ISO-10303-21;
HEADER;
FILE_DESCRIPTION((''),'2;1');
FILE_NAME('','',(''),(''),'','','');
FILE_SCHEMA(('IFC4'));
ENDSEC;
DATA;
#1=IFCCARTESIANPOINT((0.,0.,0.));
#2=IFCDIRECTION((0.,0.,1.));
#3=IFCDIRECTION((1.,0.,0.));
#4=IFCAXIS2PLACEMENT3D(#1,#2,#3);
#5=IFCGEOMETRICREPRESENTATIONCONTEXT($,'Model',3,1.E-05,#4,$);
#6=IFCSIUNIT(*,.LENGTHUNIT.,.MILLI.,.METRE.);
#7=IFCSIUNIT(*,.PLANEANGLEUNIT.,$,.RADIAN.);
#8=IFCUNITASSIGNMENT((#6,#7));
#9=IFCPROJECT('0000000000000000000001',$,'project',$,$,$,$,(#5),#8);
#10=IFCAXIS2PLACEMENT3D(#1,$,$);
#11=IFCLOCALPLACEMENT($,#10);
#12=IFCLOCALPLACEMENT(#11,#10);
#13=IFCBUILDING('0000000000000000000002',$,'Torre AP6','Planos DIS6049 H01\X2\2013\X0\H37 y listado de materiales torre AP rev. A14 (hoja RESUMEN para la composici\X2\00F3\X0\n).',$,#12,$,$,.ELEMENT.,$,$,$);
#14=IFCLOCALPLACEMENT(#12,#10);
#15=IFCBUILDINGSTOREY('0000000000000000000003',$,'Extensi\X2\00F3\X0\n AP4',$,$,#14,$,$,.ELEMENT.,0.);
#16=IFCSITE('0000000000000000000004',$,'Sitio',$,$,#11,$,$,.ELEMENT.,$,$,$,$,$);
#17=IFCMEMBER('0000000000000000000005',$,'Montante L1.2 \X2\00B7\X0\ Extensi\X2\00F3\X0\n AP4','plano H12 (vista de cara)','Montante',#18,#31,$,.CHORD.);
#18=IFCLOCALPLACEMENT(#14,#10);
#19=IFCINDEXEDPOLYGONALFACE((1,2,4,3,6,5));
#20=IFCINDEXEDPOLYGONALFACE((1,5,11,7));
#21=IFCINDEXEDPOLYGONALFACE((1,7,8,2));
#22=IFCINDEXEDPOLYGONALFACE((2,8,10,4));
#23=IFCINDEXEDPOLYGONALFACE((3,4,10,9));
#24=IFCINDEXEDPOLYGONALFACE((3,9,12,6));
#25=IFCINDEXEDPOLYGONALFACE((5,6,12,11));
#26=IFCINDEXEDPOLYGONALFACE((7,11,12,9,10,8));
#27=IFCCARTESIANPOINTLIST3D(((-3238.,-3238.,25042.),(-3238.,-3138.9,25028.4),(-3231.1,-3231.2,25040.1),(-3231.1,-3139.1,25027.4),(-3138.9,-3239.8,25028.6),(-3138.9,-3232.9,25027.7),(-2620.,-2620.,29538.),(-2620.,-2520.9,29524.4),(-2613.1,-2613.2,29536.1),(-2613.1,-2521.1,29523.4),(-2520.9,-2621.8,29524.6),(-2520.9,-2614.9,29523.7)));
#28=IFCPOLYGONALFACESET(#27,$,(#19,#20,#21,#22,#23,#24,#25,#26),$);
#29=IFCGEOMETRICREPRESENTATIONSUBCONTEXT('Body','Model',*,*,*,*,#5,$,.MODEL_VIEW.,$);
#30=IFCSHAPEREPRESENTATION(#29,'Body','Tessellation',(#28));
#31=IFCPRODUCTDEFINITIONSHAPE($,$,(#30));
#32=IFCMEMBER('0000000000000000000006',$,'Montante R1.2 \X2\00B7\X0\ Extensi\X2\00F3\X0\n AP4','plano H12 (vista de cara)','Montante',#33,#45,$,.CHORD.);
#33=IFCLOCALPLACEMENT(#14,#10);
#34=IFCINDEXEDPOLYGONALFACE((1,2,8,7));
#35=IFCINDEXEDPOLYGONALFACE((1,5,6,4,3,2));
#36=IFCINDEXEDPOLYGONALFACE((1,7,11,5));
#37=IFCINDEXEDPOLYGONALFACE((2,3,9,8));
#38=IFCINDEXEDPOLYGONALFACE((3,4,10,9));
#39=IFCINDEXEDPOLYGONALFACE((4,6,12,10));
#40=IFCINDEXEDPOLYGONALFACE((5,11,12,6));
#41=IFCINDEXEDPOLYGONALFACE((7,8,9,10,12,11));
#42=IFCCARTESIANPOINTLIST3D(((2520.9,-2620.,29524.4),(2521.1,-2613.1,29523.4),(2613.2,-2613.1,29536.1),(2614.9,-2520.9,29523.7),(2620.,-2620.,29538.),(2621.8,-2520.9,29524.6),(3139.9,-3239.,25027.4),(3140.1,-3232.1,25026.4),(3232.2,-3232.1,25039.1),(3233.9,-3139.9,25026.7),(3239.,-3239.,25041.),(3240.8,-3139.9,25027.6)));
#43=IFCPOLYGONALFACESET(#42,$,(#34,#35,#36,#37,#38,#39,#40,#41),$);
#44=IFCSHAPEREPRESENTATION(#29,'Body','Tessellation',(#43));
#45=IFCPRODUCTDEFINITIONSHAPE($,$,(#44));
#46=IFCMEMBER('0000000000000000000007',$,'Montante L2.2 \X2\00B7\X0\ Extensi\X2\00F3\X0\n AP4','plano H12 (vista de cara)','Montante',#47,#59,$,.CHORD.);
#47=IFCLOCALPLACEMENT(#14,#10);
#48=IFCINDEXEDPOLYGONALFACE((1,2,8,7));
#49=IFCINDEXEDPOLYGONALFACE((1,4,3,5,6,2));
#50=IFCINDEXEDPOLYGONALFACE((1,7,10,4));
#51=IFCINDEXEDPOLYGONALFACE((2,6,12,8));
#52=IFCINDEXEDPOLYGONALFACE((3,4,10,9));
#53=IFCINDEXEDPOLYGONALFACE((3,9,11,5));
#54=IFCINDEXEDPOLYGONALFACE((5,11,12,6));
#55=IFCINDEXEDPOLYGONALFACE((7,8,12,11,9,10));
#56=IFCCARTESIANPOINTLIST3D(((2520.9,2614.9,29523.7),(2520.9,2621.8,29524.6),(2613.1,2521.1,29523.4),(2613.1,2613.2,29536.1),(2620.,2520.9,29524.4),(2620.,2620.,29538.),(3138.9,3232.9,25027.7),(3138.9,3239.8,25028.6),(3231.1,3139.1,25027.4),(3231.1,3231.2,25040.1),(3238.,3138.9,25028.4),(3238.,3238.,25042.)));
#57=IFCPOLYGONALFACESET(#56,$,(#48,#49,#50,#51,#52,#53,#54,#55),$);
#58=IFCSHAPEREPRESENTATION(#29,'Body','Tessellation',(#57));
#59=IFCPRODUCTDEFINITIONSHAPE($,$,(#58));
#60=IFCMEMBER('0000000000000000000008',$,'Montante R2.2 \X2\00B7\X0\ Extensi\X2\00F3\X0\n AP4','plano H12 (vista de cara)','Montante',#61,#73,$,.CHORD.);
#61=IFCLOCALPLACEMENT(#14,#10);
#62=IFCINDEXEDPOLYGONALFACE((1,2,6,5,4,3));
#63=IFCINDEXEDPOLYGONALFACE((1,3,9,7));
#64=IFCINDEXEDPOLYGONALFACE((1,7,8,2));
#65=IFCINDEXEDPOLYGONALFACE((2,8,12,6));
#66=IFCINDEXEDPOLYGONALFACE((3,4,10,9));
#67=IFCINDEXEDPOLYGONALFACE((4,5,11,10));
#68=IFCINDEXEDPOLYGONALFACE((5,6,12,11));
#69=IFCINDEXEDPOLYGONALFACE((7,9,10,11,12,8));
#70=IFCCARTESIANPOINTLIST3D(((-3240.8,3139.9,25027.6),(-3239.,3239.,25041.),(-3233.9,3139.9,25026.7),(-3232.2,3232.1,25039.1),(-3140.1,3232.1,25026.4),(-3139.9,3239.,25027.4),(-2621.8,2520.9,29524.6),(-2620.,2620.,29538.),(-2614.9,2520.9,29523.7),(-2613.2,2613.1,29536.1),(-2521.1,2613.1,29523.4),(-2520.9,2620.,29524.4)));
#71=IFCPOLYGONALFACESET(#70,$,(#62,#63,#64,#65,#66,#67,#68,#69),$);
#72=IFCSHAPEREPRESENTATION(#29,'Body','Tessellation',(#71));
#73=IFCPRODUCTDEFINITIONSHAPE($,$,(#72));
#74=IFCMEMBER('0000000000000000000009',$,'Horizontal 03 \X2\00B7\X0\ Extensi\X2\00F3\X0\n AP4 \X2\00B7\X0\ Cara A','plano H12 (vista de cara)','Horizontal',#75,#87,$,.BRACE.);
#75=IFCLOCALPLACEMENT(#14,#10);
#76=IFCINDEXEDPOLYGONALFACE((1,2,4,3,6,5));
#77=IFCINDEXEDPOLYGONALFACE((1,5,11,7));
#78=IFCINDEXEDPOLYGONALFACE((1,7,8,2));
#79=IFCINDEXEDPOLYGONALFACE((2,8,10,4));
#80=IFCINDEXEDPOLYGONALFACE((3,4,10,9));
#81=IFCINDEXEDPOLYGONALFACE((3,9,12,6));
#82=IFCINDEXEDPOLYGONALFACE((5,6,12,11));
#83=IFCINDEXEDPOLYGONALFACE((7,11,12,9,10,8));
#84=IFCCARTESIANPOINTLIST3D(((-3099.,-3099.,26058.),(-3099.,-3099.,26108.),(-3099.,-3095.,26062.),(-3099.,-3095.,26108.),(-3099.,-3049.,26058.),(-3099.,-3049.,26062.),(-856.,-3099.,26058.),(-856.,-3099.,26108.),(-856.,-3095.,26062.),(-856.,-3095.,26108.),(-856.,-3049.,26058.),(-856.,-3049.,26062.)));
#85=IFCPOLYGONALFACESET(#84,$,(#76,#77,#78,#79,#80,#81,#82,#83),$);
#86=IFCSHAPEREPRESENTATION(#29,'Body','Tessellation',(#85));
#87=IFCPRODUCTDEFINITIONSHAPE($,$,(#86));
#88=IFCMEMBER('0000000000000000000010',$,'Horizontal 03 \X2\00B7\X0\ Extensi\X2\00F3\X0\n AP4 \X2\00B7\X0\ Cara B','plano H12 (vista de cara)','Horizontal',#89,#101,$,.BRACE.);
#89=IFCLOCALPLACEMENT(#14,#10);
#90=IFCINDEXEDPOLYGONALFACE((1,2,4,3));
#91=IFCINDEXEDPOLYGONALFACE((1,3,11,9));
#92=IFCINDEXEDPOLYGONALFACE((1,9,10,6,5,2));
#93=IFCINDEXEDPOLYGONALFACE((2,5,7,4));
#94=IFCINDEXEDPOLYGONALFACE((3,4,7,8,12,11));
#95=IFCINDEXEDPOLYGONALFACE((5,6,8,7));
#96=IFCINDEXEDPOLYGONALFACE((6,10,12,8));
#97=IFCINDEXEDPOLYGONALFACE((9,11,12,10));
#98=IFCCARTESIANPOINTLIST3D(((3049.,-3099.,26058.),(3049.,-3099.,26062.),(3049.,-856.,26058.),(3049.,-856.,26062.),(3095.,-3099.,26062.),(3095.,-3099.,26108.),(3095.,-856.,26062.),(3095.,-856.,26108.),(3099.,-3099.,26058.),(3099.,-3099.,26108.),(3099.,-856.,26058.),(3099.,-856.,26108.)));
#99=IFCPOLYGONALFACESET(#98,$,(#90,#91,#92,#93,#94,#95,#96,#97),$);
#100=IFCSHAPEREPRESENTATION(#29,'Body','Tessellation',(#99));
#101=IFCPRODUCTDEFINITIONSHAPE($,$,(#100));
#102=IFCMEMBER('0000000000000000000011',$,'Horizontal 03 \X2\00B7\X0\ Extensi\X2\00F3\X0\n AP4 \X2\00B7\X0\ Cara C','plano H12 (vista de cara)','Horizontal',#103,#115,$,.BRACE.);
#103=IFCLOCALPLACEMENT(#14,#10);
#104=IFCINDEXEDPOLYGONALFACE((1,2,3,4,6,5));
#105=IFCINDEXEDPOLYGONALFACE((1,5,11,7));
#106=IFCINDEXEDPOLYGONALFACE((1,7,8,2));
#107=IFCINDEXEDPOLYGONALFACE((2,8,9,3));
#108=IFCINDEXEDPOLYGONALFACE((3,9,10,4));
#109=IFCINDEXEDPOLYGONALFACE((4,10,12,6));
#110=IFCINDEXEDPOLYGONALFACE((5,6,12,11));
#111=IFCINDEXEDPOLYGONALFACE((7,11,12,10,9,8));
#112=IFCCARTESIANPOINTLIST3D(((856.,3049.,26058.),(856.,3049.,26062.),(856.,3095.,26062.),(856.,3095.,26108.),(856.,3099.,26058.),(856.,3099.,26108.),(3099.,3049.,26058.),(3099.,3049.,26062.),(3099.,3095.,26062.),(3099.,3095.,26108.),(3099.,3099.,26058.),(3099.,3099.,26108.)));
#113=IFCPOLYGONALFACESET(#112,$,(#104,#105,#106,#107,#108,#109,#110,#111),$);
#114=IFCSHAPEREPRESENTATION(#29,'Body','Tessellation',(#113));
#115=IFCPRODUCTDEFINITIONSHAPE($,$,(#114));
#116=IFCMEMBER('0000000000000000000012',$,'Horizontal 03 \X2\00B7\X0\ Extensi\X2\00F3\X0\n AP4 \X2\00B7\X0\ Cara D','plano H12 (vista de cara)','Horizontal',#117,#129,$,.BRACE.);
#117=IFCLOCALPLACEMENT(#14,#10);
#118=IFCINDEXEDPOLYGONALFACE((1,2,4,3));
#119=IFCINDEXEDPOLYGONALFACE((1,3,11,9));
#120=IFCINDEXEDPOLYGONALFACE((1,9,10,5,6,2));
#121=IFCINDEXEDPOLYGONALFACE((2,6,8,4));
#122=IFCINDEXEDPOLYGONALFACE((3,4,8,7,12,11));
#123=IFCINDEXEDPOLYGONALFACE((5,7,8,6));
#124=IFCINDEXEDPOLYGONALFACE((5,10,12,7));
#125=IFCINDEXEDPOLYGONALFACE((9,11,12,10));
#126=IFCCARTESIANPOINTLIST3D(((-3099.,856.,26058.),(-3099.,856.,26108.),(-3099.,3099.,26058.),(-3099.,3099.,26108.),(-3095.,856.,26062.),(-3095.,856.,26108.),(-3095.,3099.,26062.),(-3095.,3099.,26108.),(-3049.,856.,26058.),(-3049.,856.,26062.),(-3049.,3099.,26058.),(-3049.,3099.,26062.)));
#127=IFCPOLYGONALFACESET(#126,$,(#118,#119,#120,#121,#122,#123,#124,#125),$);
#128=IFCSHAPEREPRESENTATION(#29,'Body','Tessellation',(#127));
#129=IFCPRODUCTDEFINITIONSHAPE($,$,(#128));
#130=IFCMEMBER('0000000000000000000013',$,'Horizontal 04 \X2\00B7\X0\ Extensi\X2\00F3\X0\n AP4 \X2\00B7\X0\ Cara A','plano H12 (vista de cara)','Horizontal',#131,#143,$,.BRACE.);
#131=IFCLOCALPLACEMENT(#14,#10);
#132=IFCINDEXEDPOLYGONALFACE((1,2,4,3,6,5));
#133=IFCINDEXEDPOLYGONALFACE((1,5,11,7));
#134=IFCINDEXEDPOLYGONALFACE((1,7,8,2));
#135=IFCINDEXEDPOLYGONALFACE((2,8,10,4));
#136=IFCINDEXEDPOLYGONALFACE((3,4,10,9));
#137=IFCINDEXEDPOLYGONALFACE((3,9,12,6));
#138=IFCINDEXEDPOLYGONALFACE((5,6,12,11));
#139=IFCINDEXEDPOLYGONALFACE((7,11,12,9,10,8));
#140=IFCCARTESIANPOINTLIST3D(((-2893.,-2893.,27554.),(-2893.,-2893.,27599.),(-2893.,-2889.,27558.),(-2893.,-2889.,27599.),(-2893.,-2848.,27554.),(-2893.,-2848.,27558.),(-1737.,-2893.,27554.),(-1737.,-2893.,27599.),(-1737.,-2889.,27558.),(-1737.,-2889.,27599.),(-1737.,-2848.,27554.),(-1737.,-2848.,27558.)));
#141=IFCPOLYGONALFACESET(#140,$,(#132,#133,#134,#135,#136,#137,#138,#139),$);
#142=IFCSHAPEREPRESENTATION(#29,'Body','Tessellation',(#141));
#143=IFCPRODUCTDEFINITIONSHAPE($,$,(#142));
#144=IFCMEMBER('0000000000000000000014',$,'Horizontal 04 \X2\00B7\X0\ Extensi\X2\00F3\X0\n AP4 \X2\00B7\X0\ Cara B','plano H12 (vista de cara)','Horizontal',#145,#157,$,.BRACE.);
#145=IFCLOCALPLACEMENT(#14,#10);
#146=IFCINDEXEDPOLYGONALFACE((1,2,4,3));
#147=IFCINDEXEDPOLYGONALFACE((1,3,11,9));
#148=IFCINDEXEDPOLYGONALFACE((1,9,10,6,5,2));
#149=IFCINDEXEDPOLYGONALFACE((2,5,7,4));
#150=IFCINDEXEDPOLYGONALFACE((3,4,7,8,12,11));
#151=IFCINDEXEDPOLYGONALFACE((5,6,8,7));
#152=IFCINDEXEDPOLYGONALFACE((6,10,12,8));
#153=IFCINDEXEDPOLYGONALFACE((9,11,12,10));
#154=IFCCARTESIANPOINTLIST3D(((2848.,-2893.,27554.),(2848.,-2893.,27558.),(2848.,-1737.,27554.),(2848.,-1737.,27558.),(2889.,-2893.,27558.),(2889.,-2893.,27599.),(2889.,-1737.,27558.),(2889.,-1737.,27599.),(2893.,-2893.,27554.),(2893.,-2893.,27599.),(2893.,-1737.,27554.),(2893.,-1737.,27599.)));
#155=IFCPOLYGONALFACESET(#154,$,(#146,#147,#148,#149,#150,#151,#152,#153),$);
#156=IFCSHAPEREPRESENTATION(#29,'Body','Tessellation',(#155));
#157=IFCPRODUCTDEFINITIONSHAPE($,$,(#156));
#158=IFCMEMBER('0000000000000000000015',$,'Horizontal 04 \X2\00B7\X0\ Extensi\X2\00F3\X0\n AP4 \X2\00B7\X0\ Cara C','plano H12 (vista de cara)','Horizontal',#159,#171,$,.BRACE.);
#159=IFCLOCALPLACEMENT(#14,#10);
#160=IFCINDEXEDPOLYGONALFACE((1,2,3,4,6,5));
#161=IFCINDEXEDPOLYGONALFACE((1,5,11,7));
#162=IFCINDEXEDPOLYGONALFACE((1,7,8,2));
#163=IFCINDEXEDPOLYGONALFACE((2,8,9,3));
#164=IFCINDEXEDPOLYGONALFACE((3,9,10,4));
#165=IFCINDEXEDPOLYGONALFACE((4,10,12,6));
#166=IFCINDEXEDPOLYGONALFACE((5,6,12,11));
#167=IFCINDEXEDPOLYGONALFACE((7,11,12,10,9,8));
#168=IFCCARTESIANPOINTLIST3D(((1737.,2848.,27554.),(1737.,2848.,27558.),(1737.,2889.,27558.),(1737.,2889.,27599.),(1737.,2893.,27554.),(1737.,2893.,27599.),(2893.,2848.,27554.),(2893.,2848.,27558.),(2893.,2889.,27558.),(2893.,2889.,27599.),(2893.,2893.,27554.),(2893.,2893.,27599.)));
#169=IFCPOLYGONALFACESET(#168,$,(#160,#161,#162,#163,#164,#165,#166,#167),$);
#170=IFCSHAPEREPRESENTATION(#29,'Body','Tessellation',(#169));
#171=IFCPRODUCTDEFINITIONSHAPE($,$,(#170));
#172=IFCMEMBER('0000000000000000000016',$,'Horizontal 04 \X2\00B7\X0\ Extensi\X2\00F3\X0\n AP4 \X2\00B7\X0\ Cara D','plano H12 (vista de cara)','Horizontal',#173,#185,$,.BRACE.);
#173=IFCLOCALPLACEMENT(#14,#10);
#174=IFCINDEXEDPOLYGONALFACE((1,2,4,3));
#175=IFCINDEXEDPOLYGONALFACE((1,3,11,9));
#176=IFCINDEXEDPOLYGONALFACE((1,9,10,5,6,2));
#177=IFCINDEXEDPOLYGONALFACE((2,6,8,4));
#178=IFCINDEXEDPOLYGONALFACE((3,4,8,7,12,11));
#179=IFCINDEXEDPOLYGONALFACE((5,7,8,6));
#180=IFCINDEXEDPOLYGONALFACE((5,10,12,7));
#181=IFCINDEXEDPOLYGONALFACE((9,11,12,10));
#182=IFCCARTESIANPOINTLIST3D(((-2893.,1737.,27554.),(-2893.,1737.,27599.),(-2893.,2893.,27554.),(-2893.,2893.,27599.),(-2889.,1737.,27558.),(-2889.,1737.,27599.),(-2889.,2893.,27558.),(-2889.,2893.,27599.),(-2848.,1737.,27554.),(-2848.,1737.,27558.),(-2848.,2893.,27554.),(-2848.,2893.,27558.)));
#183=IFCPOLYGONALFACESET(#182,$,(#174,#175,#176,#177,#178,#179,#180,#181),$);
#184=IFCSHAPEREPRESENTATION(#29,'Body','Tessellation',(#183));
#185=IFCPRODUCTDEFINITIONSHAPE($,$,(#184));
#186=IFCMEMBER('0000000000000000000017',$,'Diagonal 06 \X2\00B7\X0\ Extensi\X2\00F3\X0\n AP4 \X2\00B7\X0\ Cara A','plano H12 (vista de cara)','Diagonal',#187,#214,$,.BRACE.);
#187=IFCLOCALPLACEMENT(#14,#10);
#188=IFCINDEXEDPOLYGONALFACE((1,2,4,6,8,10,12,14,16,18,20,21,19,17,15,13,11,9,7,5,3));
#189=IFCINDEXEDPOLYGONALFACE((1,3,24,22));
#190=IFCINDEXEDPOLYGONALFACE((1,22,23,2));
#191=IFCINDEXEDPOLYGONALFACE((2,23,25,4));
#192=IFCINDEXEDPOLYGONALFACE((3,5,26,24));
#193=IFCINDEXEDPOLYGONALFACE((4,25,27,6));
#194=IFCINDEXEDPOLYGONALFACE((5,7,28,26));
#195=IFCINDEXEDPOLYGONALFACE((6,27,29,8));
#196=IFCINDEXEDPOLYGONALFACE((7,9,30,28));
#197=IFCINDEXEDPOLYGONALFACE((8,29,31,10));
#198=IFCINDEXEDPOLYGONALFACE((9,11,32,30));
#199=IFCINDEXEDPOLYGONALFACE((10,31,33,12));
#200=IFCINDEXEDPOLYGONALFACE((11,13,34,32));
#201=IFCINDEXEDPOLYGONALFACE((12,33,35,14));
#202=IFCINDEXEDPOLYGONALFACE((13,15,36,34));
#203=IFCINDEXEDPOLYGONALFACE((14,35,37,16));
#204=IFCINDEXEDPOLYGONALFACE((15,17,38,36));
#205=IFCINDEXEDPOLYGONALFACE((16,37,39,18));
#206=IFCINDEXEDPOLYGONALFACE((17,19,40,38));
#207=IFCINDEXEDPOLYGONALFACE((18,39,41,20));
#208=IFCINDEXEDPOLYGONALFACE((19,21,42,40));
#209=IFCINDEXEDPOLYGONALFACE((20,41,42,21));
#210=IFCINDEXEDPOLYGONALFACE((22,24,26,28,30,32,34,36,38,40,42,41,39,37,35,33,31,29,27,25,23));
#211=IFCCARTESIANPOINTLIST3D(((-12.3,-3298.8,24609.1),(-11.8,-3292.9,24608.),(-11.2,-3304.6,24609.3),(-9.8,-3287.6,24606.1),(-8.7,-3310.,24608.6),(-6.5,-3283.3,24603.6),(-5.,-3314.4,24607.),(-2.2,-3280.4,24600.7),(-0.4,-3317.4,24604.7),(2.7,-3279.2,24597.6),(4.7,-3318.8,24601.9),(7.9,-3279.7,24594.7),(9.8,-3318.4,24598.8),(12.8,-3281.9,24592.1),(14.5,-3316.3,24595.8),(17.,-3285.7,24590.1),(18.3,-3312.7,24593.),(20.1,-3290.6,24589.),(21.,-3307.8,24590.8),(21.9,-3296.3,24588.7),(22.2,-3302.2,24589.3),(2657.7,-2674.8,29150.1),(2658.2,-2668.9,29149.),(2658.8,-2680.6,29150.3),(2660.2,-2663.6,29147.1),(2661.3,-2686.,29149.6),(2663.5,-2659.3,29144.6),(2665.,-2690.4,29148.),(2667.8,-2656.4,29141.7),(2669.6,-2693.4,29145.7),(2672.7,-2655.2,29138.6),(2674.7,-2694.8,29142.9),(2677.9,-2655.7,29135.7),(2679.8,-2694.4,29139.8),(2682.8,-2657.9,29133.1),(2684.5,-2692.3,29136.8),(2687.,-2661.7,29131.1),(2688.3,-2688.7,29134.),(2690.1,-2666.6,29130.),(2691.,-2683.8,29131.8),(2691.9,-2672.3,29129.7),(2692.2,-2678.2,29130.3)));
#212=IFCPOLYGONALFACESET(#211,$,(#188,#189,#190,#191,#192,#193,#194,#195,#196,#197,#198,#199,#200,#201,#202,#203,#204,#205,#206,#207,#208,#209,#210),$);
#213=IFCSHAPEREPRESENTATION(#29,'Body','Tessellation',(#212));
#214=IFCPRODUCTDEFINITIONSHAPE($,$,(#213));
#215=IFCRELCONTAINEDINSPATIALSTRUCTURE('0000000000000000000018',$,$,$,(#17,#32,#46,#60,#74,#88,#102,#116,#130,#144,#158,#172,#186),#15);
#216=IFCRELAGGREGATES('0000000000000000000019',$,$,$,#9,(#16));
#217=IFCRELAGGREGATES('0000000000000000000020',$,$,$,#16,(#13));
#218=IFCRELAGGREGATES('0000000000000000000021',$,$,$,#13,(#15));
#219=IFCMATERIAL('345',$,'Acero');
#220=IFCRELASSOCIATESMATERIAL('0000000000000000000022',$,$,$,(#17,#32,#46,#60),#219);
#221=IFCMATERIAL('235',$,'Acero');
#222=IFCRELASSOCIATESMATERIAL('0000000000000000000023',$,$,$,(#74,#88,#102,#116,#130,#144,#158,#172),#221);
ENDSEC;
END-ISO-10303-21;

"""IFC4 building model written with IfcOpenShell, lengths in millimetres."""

from ifc_helpers import new_model, si_unit, frame, frame_2d, origin, origin_with_axes, place, context, subcontext, project, spatial, circle, l_section, extrude, material, element, save


model = new_model("IFC4")

# Units and contexts
model_context = context("Model", 3, precision=1e-05, world=origin_with_axes())
body_context = subcontext(model_context, "Body", "Model", "MODEL_VIEW")
ifc_project = project(units=[si_unit("LENGTHUNIT", "METRE", prefix="MILLI"), si_unit("PLANEANGLEUNIT", "RADIAN")], contexts=[model_context])

# Site, building, storey
site_placement = place(None, origin())
site = spatial("IfcSite", under=ifc_project, at=site_placement, Name="Sitio", CompositionType="ELEMENT")
building_placement = place(site_placement, origin())
building = spatial("IfcBuilding", under=site, at=building_placement, Name="Torre AP6", Description="Planos DIS6049 H01–H37 y listado de materiales torre AP rev. A14 (hoja RESUMEN para la composición).", CompositionType="ELEMENT")
storey_placement = place(building_placement, origin())
storey = spatial("IfcBuildingStorey", under=building, at=storey_placement, Name="Extensión AP4", CompositionType="ELEMENT", Elevation=0.0)

# Members
ifc_material_1 = material(Name="345", Category="Acero")
member_1_placement = place(storey_placement, frame((-3238.0, -3238.0, 25042.0), z_axis=(0.13493, 0.13493, 0.981625), x_axis=(0.990855, -0.018374, -0.133673)))
element("IfcMember", 1, at=member_1_placement, inside=storey, material=ifc_material_1, Name="Montante L1.2 · Extensión AP4", Description="plano H12 (vista de cara)", ObjectType="Montante", PredefinedType="CHORD", context=body_context, shape_type="SweptSolid", body=[
    extrude(l_section(Depth=100.0, Width=100.0, Thickness=7.0, at=frame_2d((50.0, 50.0))), None, (0.0, 0.0, 1.0), 4580.2),
])
member_2_placement = place(storey_placement, frame((3239.0, -3239.0, 25041.0), z_axis=(-0.135111, 0.135111, 0.981575), x_axis=(0.018424, 0.99083, -0.133849)))
element("IfcMember", 2, at=member_2_placement, inside=storey, material=ifc_material_1, Name="Montante R1.2 · Extensión AP4", Description="plano H12 (vista de cara)", ObjectType="Montante", PredefinedType="CHORD", context=body_context, shape_type="SweptSolid", body=[
    extrude(l_section(Depth=100.0, Width=100.0, Thickness=7.0, at=frame_2d((50.0, 50.0))), None, (0.0, 0.0, 1.0), 4581.4),
])
member_3_placement = place(storey_placement, frame((3238.0, 3238.0, 25042.0), z_axis=(-0.13493, -0.13493, 0.981625), x_axis=(-0.990855, 0.018374, -0.133673)))
element("IfcMember", 3, at=member_3_placement, inside=storey, material=ifc_material_1, Name="Montante L2.2 · Extensión AP4", Description="plano H12 (vista de cara)", ObjectType="Montante", PredefinedType="CHORD", context=body_context, shape_type="SweptSolid", body=[
    extrude(l_section(Depth=100.0, Width=100.0, Thickness=7.0, at=frame_2d((50.0, 50.0))), None, (0.0, 0.0, 1.0), 4580.2),
])
member_4_placement = place(storey_placement, frame((-3239.0, 3239.0, 25041.0), z_axis=(0.135111, -0.135111, 0.981575), x_axis=(-0.018424, -0.99083, -0.133849)))
element("IfcMember", 4, at=member_4_placement, inside=storey, material=ifc_material_1, Name="Montante R2.2 · Extensión AP4", Description="plano H12 (vista de cara)", ObjectType="Montante", PredefinedType="CHORD", context=body_context, shape_type="SweptSolid", body=[
    extrude(l_section(Depth=100.0, Width=100.0, Thickness=7.0, at=frame_2d((50.0, 50.0))), None, (0.0, 0.0, 1.0), 4581.4),
])
ifc_material_2 = material(Name="235", Category="Acero")
for number, where, z_axis, x_axis, name in (
    (5, (-3099.0, -3099.0, 26058.0), (1.0, 0.0, 0.0), (0.0, 1.0, 0.0), "Horizontal 03 · Extensión AP4 · Cara A"),
    (6, (3099.0, -3099.0, 26058.0), (0.0, 1.0, 0.0), (-1.0, 0.0, 0.0), "Horizontal 03 · Extensión AP4 · Cara B"),
    (7, (3099.0, 3099.0, 26058.0), (-1.0, 0.0, 0.0), (0.0, -1.0, 0.0), "Horizontal 03 · Extensión AP4 · Cara C"),
    (8, (-3099.0, 3099.0, 26058.0), (0.0, -1.0, 0.0), (1.0, 0.0, 0.0), "Horizontal 03 · Extensión AP4 · Cara D"),
):
    element("IfcMember", number, at=place(storey_placement, frame(where, z_axis=z_axis, x_axis=x_axis)), inside=storey, material=ifc_material_2, Name=name, Description="plano H12 (vista de cara)", ObjectType="Horizontal", PredefinedType="BRACE", context=body_context, shape_type="SweptSolid", body=[
        extrude(l_section(Depth=50.0, Width=50.0, Thickness=4.0, at=frame_2d((25.0, 25.0))), None, (0.0, 0.0, 1.0), 2243.0),
    ])
for number, where, z_axis, x_axis, name in (
    (9, (-2893.0, -2893.0, 27554.0), (1.0, 0.0, 0.0), (0.0, 1.0, 0.0), "Horizontal 04 · Extensión AP4 · Cara A"),
    (10, (2893.0, -2893.0, 27554.0), (0.0, 1.0, 0.0), (-1.0, 0.0, 0.0), "Horizontal 04 · Extensión AP4 · Cara B"),
    (11, (2893.0, 2893.0, 27554.0), (-1.0, 0.0, 0.0), (0.0, -1.0, 0.0), "Horizontal 04 · Extensión AP4 · Cara C"),
    (12, (-2893.0, 2893.0, 27554.0), (0.0, -1.0, 0.0), (1.0, 0.0, 0.0), "Horizontal 04 · Extensión AP4 · Cara D"),
):
    element("IfcMember", number, at=place(storey_placement, frame(where, z_axis=z_axis, x_axis=x_axis)), inside=storey, material=ifc_material_2, Name=name, Description="plano H12 (vista de cara)", ObjectType="Horizontal", PredefinedType="BRACE", context=body_context, shape_type="SweptSolid", body=[
        extrude(l_section(Depth=45.0, Width=45.0, Thickness=4.0, at=frame_2d((22.5, 22.5))), None, (0.0, 0.0, 1.0), 1156.0),
    ])
for number, where, z_axis, x_axis, name in (
    (13, (5.0, -3299.0, 24599.0), (0.503335, 0.117633, 0.856047), (-0.361399, 0.928538, 0.0849), "Diagonal 06 · Extensión AP4 · Cara A"),
):
    element("IfcMember", number, at=place(storey_placement, frame(where, z_axis=z_axis, x_axis=x_axis)), inside=storey, Name=name, Description="plano H12 (vista de cara)", ObjectType="Diagonal", PredefinedType="BRACE", context=body_context, shape_type="SweptSolid", body=[
        extrude(circle(Radius=20.0), None, (0.0, 0.0, 1.0), 5304.6),
    ])

save(model, "model.ifc")
